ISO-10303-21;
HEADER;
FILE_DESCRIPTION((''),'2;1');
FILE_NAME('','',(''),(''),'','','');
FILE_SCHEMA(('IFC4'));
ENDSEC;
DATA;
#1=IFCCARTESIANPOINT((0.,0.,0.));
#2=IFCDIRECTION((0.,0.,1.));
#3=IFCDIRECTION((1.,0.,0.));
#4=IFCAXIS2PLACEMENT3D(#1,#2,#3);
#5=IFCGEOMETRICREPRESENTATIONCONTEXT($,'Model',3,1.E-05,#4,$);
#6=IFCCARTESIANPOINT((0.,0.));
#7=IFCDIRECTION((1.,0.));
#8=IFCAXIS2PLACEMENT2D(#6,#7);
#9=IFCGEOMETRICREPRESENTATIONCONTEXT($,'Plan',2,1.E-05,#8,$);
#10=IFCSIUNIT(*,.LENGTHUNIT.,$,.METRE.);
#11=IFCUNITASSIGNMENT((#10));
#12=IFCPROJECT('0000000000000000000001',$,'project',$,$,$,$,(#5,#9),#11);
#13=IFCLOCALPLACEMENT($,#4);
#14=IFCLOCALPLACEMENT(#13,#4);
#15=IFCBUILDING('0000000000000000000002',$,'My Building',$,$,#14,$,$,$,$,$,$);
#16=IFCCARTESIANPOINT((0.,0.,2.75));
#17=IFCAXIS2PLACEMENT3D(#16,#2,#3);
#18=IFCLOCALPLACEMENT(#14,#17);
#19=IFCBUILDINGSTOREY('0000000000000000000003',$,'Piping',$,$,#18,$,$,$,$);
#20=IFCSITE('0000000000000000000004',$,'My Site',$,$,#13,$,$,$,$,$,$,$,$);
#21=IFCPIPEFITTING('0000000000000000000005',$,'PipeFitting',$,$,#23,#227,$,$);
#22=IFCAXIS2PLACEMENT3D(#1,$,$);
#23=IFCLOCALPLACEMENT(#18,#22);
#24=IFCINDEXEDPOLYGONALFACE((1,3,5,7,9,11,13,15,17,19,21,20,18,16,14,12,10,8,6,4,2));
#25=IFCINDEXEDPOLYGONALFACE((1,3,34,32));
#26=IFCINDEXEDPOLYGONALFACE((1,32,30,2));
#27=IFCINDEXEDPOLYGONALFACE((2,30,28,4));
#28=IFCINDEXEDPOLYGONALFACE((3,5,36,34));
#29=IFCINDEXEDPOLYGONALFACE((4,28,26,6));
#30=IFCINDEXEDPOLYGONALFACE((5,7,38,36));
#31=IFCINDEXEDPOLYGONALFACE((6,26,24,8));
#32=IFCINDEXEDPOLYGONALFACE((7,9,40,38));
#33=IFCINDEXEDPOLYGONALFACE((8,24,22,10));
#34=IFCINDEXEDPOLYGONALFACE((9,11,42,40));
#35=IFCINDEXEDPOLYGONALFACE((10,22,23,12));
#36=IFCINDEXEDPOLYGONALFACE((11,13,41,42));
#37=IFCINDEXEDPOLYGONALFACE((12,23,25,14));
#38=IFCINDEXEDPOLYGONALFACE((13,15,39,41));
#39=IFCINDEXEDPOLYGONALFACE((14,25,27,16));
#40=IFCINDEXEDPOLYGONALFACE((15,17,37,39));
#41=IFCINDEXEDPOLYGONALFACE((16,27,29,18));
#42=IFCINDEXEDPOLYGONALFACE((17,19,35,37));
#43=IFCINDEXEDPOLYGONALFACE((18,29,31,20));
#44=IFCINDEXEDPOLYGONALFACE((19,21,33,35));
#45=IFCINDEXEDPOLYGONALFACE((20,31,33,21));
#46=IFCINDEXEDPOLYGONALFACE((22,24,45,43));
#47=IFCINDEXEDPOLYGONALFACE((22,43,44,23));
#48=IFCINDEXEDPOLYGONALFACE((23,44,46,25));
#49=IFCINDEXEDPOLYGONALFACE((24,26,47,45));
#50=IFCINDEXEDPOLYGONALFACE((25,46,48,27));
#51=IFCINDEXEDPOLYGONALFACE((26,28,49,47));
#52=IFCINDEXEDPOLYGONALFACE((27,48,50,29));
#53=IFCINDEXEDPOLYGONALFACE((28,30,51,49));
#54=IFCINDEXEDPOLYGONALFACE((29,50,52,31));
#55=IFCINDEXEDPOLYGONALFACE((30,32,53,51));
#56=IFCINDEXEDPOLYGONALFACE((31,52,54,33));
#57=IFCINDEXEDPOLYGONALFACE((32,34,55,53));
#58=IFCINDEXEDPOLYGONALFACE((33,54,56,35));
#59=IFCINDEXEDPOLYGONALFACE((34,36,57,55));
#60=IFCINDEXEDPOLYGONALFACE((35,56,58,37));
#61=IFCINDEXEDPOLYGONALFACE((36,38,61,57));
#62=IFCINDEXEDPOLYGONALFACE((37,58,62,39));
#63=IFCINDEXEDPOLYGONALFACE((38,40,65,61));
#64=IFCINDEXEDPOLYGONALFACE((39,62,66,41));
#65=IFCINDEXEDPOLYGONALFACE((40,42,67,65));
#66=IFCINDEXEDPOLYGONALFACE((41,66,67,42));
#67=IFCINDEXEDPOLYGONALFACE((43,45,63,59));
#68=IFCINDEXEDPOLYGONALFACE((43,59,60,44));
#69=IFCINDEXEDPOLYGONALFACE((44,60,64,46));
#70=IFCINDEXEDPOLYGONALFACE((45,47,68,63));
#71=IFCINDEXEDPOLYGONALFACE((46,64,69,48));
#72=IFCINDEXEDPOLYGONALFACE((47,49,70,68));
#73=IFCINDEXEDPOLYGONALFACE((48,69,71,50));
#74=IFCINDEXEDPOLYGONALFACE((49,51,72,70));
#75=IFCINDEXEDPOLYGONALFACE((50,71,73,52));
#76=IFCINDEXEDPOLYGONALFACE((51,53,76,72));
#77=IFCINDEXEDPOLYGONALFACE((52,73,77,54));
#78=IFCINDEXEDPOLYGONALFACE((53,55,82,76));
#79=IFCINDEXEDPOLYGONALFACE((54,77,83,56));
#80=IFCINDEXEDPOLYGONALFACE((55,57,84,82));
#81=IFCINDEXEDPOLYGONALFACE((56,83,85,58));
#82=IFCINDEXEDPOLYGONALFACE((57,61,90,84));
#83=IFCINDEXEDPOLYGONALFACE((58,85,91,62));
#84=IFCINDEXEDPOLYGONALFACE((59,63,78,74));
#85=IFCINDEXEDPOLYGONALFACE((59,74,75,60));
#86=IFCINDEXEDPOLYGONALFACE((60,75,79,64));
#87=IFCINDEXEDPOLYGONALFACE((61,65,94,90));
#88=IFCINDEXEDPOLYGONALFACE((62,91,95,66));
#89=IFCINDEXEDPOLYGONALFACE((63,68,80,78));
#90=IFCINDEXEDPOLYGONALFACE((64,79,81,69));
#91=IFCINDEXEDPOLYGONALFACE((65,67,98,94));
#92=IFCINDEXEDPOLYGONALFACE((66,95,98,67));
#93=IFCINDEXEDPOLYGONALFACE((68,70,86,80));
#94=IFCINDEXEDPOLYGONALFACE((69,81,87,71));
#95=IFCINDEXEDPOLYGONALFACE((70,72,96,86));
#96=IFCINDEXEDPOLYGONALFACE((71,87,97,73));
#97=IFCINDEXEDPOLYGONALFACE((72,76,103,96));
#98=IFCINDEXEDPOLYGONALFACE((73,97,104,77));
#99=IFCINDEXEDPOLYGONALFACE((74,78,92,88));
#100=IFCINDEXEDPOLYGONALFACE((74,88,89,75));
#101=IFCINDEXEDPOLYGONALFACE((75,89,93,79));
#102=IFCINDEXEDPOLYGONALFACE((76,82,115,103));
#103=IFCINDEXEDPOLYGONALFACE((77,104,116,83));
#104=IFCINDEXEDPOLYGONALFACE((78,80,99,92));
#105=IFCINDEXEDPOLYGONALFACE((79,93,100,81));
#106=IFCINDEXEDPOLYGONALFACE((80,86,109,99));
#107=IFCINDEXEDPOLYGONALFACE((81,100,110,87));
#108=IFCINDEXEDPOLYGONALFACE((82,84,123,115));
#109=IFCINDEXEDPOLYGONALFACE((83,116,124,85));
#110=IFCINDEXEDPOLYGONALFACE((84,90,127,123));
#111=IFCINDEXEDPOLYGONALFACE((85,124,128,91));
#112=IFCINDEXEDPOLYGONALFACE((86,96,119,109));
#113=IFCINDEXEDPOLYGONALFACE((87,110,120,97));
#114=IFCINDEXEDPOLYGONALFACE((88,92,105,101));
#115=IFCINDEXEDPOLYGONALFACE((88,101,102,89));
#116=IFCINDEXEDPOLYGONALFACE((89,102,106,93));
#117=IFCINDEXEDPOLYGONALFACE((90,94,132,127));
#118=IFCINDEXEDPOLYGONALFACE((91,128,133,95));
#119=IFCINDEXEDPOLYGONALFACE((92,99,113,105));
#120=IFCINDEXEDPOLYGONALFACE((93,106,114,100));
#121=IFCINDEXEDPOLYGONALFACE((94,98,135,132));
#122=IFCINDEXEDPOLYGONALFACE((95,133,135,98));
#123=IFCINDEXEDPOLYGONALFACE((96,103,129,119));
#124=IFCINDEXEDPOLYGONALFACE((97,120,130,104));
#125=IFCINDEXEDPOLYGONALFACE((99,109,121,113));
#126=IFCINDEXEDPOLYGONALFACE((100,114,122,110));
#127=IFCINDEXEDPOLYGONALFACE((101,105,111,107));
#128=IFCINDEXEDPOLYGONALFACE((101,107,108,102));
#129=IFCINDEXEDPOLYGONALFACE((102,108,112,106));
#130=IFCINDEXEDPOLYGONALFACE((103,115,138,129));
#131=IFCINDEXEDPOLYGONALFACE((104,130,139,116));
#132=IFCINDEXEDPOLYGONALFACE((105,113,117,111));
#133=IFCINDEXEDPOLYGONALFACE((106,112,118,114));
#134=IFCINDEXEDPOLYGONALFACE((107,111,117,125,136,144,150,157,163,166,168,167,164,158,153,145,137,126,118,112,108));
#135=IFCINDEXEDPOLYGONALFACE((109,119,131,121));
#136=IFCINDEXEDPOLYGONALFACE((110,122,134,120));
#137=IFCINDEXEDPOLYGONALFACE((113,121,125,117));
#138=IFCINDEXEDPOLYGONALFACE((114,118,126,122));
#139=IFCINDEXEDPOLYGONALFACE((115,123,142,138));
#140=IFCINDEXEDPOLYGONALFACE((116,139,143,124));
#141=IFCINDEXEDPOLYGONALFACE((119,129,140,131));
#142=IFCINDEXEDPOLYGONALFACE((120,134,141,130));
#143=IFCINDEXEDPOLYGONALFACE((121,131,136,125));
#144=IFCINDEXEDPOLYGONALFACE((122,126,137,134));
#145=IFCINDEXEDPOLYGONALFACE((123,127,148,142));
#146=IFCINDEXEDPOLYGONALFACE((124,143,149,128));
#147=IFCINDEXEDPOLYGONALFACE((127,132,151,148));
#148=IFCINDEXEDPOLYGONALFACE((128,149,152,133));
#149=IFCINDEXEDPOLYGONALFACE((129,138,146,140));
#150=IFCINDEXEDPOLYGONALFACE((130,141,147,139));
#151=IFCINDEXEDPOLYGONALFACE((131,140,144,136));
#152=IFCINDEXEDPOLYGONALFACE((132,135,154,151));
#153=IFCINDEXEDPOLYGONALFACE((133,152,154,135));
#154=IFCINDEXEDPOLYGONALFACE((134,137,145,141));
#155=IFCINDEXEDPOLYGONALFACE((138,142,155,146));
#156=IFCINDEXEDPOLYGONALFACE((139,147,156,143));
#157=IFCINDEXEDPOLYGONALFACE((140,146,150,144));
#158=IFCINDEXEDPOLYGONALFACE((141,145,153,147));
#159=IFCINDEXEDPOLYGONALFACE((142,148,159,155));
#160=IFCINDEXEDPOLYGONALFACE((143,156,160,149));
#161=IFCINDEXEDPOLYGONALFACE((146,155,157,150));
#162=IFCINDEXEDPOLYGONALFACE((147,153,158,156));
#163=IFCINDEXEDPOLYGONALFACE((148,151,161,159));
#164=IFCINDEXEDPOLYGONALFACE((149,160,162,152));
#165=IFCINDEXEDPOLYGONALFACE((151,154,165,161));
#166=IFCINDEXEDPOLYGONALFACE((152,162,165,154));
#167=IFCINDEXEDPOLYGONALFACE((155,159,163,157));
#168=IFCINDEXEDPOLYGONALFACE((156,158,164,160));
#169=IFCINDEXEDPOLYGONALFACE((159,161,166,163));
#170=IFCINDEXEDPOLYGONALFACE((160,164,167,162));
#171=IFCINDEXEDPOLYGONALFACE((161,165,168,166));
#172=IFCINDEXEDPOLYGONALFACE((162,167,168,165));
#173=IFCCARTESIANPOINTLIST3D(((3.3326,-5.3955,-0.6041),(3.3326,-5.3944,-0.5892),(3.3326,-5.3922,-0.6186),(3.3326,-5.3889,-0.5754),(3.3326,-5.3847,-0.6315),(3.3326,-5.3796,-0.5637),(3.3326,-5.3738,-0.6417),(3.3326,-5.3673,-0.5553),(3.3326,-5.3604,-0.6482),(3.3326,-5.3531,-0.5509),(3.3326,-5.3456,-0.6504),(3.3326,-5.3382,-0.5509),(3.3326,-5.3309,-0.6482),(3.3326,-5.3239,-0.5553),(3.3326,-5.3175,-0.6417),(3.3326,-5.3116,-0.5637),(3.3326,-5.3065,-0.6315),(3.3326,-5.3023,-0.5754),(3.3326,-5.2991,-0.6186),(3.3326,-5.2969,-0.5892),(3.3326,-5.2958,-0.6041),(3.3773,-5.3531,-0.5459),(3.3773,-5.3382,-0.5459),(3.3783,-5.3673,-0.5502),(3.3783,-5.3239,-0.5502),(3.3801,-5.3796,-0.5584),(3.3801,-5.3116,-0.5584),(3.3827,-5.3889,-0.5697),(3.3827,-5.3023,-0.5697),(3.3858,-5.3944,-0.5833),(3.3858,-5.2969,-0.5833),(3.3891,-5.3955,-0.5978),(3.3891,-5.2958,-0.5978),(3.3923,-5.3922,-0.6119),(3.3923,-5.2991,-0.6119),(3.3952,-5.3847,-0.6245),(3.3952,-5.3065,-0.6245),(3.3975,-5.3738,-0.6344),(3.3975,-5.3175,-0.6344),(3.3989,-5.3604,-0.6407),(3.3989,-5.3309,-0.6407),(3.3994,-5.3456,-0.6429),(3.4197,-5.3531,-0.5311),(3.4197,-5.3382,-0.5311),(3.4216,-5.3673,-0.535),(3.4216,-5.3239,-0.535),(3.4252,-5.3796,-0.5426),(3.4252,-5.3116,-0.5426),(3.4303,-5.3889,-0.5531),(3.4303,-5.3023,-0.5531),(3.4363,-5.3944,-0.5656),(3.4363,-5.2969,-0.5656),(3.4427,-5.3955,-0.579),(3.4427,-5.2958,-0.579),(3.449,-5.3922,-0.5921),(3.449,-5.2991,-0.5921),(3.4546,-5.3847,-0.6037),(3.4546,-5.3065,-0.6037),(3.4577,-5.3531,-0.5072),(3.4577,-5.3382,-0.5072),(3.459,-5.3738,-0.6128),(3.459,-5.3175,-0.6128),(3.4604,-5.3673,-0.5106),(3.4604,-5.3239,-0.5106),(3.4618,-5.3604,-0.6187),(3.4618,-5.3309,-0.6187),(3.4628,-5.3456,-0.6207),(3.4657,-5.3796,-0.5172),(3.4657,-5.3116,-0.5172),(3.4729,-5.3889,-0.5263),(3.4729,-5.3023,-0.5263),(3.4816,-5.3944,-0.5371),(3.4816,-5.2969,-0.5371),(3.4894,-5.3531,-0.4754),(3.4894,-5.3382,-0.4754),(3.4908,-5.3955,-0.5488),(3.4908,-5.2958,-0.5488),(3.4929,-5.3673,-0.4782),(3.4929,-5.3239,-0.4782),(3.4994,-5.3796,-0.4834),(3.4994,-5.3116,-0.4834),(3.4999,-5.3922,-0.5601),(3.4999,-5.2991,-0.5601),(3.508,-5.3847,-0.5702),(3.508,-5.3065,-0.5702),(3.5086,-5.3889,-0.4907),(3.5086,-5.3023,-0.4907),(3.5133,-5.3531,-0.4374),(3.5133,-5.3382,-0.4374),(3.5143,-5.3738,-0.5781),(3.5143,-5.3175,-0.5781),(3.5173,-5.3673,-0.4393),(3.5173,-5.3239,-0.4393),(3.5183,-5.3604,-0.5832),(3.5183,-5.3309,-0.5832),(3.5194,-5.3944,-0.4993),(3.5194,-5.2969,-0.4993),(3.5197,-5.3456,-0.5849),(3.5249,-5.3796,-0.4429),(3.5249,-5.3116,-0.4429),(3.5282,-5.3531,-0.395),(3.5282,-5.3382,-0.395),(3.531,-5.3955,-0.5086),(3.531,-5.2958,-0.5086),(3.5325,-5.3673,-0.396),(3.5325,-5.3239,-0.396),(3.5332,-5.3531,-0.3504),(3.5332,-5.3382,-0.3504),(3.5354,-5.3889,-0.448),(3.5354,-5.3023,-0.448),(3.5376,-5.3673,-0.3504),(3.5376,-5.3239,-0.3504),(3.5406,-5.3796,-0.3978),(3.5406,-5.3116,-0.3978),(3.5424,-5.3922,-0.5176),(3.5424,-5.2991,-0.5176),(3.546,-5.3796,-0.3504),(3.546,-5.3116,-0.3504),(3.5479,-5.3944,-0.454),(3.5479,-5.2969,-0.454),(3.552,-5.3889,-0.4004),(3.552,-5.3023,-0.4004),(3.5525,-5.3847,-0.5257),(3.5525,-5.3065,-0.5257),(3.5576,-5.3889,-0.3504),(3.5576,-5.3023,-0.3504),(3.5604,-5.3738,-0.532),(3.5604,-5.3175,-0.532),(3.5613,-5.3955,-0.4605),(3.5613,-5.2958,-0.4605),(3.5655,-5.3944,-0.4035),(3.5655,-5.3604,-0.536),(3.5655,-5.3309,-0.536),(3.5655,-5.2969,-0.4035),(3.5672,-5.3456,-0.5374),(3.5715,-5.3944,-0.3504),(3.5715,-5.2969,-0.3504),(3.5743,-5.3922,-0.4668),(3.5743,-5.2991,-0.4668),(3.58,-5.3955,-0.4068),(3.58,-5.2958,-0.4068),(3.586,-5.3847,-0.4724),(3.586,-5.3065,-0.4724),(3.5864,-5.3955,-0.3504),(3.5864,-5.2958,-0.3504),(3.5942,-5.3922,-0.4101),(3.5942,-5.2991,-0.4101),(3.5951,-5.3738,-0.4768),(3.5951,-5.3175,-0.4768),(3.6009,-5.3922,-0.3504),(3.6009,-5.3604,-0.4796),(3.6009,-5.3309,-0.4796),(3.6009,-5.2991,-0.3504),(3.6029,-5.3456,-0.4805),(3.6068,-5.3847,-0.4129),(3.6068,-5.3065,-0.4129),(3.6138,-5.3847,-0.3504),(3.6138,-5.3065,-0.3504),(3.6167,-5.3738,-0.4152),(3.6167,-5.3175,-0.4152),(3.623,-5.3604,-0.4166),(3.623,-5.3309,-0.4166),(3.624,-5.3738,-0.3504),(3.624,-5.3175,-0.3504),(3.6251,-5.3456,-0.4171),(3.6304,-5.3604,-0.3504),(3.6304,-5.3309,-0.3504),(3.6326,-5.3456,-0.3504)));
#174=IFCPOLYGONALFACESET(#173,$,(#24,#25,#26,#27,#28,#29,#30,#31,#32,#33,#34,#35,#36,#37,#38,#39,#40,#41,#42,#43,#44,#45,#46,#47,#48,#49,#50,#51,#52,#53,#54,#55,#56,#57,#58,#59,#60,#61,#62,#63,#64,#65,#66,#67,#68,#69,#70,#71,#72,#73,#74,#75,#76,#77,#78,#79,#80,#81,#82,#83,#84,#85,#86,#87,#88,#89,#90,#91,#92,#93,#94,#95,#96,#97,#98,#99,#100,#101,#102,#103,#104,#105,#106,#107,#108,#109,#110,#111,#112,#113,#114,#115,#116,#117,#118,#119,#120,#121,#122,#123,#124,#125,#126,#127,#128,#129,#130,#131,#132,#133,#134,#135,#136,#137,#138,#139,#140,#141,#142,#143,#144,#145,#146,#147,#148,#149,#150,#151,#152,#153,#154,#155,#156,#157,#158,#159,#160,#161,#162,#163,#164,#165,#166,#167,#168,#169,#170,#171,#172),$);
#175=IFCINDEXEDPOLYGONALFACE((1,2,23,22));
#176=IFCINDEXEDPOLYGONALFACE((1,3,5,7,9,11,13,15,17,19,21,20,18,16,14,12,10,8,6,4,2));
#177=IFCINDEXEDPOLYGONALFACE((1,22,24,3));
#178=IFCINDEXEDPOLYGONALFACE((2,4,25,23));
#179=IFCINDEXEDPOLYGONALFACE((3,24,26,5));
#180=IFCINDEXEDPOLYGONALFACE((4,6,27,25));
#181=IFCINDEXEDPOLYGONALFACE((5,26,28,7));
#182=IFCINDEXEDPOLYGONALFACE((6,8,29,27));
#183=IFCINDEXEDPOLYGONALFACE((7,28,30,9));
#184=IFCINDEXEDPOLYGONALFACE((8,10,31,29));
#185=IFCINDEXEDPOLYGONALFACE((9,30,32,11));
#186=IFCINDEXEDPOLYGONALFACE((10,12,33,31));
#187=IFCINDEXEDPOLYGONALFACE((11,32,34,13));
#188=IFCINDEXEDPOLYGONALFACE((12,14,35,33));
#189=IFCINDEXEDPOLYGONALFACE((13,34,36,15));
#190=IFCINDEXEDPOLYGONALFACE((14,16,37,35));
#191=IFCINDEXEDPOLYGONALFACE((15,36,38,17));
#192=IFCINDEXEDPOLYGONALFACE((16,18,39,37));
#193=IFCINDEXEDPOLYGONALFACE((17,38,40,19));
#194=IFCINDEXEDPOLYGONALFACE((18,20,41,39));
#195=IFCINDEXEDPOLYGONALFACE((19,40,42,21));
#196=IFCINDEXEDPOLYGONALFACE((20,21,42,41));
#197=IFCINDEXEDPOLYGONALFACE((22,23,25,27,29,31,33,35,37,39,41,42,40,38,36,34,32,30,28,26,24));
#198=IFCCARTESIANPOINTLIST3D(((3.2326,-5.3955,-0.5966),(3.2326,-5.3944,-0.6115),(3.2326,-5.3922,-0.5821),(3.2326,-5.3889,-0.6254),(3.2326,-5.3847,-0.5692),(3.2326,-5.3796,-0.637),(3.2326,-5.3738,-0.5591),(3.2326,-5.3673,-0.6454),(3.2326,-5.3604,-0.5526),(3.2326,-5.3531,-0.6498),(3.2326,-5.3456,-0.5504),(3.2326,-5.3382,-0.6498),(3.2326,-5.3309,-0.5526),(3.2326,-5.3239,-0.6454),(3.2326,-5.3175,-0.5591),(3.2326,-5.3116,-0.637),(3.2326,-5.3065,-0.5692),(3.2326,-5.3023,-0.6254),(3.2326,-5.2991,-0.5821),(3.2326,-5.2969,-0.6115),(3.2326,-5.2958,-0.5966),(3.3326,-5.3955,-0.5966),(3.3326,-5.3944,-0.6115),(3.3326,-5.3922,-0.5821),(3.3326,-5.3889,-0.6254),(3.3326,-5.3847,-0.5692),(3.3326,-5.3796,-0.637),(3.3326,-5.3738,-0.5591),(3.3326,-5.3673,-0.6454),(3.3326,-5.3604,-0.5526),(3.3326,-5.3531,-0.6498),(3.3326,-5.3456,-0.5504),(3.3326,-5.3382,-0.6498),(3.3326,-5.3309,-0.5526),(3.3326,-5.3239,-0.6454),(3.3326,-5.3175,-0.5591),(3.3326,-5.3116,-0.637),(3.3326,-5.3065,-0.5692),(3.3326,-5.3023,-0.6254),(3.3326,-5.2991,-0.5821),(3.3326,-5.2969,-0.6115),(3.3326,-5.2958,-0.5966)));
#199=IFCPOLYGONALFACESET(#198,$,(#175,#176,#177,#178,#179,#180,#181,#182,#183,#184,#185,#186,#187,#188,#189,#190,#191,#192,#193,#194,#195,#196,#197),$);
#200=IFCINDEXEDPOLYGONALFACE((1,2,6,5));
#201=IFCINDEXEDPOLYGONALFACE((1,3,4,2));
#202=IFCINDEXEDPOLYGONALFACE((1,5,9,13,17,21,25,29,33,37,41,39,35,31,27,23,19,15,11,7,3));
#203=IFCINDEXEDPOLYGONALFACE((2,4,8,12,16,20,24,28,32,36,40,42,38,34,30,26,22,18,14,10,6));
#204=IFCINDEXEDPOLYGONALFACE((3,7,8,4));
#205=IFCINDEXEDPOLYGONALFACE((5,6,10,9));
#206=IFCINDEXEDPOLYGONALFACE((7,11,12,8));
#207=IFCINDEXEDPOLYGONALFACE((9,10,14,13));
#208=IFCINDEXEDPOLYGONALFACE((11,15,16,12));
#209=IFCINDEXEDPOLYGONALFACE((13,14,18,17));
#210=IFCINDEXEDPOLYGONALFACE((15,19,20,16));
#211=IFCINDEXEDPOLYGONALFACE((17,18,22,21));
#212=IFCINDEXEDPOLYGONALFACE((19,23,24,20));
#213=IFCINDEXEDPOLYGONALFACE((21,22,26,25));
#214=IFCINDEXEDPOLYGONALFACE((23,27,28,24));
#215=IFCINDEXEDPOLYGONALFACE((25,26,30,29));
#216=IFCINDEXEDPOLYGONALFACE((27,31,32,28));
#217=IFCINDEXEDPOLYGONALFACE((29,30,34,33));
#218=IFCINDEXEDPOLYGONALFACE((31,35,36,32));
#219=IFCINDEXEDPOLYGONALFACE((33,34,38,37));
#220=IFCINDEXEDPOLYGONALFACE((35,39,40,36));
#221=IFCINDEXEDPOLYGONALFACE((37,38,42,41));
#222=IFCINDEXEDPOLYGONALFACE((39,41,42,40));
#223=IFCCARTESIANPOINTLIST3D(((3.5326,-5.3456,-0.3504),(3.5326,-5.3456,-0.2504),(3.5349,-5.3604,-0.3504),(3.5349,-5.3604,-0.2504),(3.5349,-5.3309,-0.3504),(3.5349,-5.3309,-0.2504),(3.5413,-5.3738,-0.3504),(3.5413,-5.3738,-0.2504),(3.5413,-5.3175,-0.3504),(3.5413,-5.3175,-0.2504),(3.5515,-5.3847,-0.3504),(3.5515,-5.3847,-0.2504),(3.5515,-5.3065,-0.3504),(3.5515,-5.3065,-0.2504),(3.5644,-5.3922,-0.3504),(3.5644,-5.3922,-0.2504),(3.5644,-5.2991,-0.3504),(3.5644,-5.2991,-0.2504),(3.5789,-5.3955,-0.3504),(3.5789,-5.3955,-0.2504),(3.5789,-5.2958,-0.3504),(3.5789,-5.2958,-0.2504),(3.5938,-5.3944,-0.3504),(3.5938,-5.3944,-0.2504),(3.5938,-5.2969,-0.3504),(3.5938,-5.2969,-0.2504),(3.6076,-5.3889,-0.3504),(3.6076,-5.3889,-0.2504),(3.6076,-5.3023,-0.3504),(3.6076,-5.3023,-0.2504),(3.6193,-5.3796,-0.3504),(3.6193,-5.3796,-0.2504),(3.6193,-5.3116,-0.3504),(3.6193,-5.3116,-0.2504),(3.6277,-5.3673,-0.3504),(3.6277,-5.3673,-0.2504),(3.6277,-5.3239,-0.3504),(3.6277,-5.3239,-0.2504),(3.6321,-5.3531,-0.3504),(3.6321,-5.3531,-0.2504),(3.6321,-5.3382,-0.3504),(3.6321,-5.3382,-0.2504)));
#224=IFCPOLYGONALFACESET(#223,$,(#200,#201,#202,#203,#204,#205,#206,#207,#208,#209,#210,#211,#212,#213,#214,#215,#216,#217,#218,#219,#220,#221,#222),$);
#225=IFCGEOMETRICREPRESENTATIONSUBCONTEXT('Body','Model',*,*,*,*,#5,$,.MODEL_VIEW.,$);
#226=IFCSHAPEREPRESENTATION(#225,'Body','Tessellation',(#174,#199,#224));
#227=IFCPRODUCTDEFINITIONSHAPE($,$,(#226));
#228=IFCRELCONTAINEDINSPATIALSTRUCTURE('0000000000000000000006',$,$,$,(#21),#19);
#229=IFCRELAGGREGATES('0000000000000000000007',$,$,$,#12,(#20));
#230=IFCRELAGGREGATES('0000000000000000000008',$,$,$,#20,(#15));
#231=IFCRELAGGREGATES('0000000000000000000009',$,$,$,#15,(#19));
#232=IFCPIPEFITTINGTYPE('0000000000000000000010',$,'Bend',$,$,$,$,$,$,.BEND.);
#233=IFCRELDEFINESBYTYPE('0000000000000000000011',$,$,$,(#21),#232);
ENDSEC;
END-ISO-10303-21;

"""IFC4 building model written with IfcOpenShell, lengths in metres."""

from ifc_helpers import new_model, entity, si_unit, frame, origin_with_axes, origin_2d_with_axis, place, context, subcontext, project, spatial, circle, extrude, source, transform, mapped, type_object, type_shapes, element, save


model = new_model("IFC4")

# Units and contexts
model_context = context("Model", 3, precision=1e-05, world=origin_with_axes())
plan_context = context("Plan", 2, precision=1e-05, world=origin_2d_with_axis())
body_context = subcontext(model_context, "Body", "Model", "MODEL_VIEW")
ifc_project = project(units=[si_unit("LENGTHUNIT", "METRE")], contexts=[model_context, plan_context])

# Site, building, storey
site_placement = place(None, origin_with_axes())
site = spatial("IfcSite", under=ifc_project, at=site_placement, Name="My Site")
building_placement = place(site_placement, origin_with_axes())
building = spatial("IfcBuilding", under=site, at=building_placement, Name="My Building")
storey_placement = place(building_placement, frame((0.0, 0.0, 2.75), z_axis=(0.0, 0.0, 1.0), x_axis=(1.0, 0.0, 0.0)))
storey = spatial("IfcBuildingStorey", under=building, at=storey_placement, Name="Piping")

# Pipe fitting
pipe_fitting_type = type_object("IfcPipeFittingType", Name="Bend", PredefinedType="BEND")
shared_shape = source(origin_with_axes(), body_context, "Body", "SolidModel", [
    entity("IfcSweptDiskSolid", entity("IfcIndexedPolyCurve", entity("IfcCartesianPointList3D", [[0.0, 0.0, -0.1], [0.0732, 0.0, -0.2768], [0.25, 0.0, -0.35]]), [entity("IfcArcIndex", [1, 2, 3])]), 0.05),
    extrude(circle(Radius=0.05), origin_with_axes(), (0.0, 0.0, -1.0), 0.1),
    extrude(circle(Radius=0.05), frame((0.25, 0.0, -0.35), z_axis=(1.0, 0.0, 0.0), x_axis=(0.0, 0.0, 1.0)), (0.0, 0.0, 1.0), 0.1),
])
type_shapes(pipe_fitting_type, [shared_shape])
for number, where, z_axis, x_axis, name in (
    (1, (3.2326, -5.3456, -0.6004), (-1.0, 0.0, 0.0), (0.0, 0.0, 1.0), "PipeFitting"),
):
    element("IfcPipeFitting", number, at=place(storey_placement, frame(where, z_axis=z_axis, x_axis=x_axis)), inside=storey, type_object=pipe_fitting_type, Name=name, context=body_context, shape_type="MappedRepresentation", body=[
        mapped(shared_shape, transform((0.0, 0.0, 0.0), x_axis=(1.0, 0.0, 0.0), y_axis=(0.0, 1.0, 0.0), z_axis=(0.0, 0.0, 1.0), scale=1.0)),
    ])

save(model, "model.ifc")
